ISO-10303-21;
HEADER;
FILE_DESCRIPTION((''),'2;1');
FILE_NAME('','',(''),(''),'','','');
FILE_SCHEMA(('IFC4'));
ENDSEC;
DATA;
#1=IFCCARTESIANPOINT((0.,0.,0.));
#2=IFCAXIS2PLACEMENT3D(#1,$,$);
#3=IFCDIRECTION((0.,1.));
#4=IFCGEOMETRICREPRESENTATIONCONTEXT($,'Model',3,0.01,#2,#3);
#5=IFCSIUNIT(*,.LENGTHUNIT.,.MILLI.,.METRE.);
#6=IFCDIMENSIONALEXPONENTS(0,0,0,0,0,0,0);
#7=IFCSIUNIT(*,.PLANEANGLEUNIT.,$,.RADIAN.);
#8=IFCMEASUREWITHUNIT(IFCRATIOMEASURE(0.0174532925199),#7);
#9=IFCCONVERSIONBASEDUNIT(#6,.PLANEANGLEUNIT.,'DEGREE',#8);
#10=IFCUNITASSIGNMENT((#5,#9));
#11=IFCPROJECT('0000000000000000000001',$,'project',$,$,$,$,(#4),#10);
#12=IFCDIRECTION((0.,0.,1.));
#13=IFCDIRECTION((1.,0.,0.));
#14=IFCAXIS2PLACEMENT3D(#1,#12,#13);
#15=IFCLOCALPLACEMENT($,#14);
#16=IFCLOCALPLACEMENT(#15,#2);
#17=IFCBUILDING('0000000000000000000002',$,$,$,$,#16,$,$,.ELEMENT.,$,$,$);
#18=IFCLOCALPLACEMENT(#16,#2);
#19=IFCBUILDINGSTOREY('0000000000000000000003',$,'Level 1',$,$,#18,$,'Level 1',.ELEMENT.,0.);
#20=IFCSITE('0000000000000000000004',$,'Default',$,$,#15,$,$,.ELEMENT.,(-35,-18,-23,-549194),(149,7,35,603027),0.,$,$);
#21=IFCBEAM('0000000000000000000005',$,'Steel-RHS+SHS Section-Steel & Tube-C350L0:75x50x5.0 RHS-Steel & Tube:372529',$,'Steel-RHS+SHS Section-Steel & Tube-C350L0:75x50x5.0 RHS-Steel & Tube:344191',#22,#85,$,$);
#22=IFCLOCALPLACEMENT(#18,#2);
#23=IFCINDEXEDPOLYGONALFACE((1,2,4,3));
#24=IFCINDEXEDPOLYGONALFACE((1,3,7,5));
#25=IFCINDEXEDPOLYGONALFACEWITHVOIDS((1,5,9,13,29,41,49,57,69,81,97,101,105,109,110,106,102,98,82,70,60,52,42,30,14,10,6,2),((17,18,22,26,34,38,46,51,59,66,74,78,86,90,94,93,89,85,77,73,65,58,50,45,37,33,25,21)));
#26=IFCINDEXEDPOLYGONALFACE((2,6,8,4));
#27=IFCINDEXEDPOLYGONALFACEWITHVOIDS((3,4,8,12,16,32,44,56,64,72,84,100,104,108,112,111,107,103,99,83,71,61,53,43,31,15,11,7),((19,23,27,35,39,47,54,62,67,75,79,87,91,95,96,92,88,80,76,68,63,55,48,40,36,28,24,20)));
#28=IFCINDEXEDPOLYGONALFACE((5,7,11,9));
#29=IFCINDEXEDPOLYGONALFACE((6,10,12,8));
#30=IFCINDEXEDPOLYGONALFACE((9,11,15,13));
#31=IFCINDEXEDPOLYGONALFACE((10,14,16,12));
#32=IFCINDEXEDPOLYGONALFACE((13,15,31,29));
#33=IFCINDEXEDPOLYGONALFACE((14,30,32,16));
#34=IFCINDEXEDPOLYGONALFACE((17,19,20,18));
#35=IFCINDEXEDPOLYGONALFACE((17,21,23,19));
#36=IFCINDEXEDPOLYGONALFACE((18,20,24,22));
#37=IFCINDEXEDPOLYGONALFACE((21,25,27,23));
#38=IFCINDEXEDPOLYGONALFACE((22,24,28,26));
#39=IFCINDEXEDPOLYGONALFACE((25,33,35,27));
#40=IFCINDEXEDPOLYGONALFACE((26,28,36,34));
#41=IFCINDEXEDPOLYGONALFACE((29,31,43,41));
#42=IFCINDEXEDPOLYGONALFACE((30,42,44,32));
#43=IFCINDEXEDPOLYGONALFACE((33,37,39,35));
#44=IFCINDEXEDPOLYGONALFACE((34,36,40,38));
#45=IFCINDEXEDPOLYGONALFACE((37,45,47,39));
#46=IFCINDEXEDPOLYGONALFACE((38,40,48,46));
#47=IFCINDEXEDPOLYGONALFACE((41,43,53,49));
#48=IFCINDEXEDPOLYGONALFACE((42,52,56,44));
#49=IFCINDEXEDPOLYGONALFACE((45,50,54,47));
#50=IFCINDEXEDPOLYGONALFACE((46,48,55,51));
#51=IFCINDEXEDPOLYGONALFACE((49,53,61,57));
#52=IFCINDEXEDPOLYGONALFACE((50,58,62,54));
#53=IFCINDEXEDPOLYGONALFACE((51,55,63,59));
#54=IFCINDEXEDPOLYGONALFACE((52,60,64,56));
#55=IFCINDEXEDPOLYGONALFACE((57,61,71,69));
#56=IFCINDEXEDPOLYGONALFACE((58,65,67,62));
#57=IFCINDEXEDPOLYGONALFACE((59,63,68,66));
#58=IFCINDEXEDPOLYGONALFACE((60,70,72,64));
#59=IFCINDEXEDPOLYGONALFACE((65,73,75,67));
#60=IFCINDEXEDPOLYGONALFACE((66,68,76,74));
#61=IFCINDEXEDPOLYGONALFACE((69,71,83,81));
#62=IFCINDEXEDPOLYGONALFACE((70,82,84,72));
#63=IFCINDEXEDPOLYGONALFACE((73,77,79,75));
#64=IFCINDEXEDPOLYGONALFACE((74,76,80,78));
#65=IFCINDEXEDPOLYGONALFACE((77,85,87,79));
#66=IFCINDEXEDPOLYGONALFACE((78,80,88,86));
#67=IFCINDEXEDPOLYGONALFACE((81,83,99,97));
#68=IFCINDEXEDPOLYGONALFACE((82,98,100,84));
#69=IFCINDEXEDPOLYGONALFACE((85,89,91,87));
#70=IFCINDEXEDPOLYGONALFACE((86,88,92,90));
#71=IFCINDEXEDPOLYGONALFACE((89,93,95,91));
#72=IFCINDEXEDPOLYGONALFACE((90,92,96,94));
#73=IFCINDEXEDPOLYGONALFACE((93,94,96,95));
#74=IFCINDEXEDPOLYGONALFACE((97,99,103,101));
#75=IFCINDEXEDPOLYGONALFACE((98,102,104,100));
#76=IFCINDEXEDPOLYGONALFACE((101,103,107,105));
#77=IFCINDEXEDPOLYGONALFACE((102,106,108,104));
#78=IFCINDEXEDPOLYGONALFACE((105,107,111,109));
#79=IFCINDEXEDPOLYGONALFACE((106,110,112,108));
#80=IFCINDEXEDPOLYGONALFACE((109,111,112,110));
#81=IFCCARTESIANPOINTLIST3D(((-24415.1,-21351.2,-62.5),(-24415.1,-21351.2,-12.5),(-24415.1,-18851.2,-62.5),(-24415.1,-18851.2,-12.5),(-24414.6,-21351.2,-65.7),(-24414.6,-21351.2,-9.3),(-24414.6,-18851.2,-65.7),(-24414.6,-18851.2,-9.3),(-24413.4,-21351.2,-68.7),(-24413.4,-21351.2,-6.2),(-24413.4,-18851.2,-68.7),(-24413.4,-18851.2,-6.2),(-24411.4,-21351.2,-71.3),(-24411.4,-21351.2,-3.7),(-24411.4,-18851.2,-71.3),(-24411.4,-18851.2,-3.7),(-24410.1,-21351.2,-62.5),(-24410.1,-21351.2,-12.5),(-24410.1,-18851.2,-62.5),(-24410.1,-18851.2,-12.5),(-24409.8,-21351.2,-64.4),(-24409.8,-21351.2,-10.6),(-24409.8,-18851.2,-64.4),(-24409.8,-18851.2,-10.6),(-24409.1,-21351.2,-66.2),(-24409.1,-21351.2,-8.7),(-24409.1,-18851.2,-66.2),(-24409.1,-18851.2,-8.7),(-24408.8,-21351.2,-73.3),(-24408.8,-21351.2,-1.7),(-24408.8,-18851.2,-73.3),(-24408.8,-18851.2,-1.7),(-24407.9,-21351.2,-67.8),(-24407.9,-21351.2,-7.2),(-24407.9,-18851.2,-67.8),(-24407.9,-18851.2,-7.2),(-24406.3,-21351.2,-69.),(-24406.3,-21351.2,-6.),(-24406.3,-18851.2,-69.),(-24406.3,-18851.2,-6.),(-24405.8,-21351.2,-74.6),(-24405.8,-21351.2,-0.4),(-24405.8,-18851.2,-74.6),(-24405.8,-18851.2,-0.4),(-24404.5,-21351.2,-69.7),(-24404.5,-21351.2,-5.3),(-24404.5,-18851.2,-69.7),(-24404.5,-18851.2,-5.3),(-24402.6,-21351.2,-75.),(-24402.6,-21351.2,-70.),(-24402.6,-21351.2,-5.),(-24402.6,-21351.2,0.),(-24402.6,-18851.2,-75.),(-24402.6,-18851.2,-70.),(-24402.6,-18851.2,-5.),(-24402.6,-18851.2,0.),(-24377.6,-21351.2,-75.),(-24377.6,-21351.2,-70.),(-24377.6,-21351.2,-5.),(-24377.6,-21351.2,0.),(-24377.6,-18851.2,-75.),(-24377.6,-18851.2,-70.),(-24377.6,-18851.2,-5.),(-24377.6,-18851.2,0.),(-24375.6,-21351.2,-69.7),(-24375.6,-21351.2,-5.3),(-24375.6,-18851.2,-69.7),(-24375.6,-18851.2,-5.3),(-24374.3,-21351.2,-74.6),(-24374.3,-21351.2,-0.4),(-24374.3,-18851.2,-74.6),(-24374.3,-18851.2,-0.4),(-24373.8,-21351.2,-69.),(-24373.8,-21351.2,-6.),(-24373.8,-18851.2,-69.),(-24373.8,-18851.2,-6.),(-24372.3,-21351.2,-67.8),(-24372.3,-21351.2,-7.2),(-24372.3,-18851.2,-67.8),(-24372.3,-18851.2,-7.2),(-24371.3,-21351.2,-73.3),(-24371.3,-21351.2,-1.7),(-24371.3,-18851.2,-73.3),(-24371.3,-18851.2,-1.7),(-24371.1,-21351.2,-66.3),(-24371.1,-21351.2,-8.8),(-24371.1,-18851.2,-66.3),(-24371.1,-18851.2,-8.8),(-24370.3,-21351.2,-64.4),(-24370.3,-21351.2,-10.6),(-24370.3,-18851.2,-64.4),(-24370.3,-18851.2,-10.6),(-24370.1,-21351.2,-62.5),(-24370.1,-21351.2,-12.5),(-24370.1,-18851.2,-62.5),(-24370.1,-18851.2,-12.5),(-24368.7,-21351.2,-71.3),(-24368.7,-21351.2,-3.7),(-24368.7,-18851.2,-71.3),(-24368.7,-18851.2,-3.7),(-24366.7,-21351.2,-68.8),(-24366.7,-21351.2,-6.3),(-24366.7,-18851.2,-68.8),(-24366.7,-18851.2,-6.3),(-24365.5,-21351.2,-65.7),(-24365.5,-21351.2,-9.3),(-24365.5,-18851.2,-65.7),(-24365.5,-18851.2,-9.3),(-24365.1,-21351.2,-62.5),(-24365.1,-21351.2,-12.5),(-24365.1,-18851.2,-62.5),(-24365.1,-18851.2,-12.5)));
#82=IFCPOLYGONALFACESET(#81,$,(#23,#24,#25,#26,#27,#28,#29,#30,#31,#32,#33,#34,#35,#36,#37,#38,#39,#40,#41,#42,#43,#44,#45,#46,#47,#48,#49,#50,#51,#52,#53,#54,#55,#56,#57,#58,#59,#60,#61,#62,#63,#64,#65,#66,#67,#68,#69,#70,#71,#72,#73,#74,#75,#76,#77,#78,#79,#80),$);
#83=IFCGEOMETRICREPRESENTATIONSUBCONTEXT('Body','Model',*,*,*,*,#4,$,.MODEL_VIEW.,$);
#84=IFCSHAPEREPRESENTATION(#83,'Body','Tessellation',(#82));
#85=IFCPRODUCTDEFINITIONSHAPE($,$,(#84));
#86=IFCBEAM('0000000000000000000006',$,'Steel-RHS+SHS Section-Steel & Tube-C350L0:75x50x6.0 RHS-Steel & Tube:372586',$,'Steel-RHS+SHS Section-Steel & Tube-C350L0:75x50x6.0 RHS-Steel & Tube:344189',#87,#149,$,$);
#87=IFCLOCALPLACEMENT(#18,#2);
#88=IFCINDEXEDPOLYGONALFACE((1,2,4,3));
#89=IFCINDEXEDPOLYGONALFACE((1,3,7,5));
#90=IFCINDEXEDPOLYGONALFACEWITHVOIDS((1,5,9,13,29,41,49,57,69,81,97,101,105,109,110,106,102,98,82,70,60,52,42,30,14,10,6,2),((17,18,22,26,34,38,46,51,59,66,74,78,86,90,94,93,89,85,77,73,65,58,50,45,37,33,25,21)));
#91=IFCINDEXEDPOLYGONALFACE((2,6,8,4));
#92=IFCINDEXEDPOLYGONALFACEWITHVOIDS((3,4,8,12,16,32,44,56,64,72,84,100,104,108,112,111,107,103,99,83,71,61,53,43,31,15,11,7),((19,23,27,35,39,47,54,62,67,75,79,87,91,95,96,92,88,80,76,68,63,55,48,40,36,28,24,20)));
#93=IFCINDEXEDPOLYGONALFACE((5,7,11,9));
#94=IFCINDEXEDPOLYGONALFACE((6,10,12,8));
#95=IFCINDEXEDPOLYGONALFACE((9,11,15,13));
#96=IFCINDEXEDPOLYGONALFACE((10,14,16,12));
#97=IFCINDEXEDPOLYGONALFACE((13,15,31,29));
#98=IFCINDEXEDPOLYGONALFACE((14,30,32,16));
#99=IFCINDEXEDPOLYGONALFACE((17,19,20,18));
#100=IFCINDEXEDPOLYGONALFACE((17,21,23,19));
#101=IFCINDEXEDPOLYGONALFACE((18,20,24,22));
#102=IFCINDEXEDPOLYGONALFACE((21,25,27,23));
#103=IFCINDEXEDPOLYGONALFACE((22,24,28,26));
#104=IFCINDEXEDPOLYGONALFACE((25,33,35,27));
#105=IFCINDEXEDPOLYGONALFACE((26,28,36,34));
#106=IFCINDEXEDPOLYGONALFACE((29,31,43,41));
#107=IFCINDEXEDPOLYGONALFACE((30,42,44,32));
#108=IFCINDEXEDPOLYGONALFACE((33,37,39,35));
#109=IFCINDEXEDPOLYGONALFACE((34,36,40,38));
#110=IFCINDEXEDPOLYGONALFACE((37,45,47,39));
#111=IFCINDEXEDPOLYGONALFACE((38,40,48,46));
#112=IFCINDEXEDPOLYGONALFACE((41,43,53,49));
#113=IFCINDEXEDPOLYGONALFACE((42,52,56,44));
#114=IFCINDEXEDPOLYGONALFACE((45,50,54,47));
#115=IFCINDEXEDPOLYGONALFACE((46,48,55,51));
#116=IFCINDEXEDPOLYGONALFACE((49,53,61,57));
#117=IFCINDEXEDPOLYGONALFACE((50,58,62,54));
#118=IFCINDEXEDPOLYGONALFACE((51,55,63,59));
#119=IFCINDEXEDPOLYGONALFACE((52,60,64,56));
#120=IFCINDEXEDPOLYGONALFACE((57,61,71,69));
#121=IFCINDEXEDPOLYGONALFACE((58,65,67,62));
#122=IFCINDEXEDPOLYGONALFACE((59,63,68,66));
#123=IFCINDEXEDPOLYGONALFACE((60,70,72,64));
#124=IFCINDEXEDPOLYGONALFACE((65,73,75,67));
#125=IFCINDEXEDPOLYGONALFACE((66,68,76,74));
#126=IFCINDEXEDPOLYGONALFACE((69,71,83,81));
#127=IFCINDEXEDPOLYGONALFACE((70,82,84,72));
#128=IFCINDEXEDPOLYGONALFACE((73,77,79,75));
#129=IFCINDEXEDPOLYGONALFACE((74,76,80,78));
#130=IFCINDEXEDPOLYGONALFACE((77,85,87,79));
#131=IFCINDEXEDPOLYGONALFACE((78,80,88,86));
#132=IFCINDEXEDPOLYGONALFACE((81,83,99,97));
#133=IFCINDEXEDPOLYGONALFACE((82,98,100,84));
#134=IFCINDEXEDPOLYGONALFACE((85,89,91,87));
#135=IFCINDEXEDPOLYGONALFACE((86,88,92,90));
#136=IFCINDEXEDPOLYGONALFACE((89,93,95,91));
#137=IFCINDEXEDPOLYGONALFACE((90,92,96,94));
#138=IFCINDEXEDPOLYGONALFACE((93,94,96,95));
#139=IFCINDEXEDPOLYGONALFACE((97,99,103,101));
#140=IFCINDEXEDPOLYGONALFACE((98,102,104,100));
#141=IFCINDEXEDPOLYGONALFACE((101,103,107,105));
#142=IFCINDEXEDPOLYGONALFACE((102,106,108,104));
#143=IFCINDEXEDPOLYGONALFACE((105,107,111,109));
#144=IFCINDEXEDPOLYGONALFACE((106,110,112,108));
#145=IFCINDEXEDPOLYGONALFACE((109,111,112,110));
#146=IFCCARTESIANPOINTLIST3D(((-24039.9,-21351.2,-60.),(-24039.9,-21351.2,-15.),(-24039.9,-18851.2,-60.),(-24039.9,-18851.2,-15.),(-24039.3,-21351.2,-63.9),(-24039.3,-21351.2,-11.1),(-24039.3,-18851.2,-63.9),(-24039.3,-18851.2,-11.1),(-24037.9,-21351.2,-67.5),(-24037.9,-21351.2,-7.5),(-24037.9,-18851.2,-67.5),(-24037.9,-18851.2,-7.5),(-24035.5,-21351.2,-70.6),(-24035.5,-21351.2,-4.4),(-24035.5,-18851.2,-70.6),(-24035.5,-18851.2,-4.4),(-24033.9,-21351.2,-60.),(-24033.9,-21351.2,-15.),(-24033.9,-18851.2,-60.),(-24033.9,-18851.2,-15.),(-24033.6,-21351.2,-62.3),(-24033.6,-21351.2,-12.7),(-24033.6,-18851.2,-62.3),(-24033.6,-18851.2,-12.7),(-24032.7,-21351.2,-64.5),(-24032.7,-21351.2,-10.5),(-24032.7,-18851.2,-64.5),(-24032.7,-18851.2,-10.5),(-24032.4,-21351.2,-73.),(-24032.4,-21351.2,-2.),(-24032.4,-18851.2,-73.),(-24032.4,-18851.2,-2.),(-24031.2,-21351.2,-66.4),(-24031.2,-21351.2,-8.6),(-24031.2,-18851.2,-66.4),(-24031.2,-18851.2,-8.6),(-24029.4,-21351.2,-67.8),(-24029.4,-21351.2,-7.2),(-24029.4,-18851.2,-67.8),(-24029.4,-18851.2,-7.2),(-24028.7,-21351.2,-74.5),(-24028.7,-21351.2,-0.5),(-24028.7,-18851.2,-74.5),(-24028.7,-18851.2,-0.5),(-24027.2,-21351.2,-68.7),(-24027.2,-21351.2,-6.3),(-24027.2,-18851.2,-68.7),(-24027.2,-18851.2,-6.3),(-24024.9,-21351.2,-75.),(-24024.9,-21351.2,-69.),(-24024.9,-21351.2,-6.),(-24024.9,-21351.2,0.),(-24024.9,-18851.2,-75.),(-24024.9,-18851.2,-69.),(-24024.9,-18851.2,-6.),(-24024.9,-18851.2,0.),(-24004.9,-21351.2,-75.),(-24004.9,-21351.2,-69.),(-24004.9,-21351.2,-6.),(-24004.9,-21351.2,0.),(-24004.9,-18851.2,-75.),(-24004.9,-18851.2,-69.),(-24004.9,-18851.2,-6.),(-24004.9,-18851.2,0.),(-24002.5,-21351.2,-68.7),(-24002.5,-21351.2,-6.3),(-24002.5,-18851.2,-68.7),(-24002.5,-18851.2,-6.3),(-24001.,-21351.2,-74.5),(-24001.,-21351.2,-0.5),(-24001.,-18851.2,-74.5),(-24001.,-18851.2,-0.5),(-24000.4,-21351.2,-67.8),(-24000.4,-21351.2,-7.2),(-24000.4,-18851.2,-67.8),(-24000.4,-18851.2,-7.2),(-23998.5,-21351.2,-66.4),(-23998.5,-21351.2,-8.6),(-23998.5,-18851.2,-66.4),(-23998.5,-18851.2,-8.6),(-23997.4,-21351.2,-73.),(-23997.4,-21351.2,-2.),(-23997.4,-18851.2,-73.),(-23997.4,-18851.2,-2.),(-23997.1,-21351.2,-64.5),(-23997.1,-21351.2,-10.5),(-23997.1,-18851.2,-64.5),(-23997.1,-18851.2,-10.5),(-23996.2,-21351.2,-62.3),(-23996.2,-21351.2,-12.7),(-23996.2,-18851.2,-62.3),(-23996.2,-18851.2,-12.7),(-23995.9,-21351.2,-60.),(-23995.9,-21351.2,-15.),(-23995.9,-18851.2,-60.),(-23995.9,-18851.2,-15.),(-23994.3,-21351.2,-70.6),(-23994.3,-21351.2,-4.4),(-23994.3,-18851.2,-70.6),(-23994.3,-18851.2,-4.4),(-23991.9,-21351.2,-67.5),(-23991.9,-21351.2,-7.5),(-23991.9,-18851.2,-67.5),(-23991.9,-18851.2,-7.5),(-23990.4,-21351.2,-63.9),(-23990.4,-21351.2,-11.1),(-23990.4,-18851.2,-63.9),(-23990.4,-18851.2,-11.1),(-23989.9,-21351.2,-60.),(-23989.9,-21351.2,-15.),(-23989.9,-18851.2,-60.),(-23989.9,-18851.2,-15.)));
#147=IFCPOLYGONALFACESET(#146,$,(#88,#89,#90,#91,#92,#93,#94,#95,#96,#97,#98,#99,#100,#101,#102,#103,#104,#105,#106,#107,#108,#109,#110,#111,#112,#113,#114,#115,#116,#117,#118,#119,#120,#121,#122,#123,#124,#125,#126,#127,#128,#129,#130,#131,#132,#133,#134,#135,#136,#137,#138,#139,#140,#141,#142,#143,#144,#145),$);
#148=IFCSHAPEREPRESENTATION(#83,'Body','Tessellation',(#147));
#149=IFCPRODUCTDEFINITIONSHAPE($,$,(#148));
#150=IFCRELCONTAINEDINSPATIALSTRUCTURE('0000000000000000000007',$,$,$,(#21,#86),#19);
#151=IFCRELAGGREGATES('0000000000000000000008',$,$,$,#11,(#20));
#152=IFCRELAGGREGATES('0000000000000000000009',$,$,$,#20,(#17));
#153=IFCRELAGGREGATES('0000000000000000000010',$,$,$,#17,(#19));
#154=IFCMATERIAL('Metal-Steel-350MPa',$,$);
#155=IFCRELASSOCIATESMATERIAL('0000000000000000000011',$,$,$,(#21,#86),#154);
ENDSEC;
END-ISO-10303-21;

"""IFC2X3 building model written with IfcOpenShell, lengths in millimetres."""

from ifc_helpers import new_model, entity, si_unit, converted_unit, direction, frame, frame_2d, origin, origin_with_axes, place, context, subcontext, project, spatial, polyline, circle_curve, parameter, trimmed, segment, composite_curve, outline, extrude, material, element, save


model = new_model("IFC2X3")

# Units and contexts
model_context = context("Model", 3, precision=0.01, world=origin(), true_north=direction((0.0, 1.0)))
body_context = subcontext(model_context, "Body", "Model", "MODEL_VIEW")
ifc_project = project(units=[si_unit("LENGTHUNIT", "METRE", prefix="MILLI"), converted_unit("PLANEANGLEUNIT", "DEGREE", entity("IfcRatioMeasure", 0.0174532925199), si_unit("PLANEANGLEUNIT", "RADIAN"), dimensions=[0, 0, 0, 0, 0, 0, 0])], contexts=[model_context])

# Site, building, storey
site_placement = place(None, origin_with_axes())
site = spatial("IfcSite", under=ifc_project, at=site_placement, Name="Default", CompositionType="ELEMENT", RefLatitude=(-35, -18, -23, -549194), RefLongitude=(149, 7, 35, 603027), RefElevation=0.0)
building_placement = place(site_placement, origin())
building = spatial("IfcBuilding", under=site, at=building_placement, CompositionType="ELEMENT")
storey_placement = place(building_placement, origin())
storey = spatial("IfcBuildingStorey", under=building, at=storey_placement, Name="Level 1", LongName="Level 1", CompositionType="ELEMENT", Elevation=0.0)

# Beams
ifc_material = material(Name="Metal-Steel-350MPa")
beam_1_placement = place(storey_placement, frame((-24390.1, -18851.2, 0.0), z_axis=(0.0, 0.0, 1.0), x_axis=(0.0, -1.0, 0.0)))
element("IfcBeam", 1, at=beam_1_placement, inside=storey, material=ifc_material, Name="Steel-RHS+SHS Section-Steel & Tube-C350L0:75x50x5.0 RHS-Steel & Tube:372529", ObjectType="Steel-RHS+SHS Section-Steel & Tube-C350L0:75x50x5.0 RHS-Steel & Tube:344191", context=body_context, shape_type="SweptSolid", body=[
    extrude(outline(composite_curve([segment(trimmed(circle_curve(frame_2d((-12.5, -25.0), x_axis=(1.0, 0.0)), 12.5), [parameter(180.0)], [parameter(270.0)], True, "PARAMETER"), True, "CONTINUOUS"), segment(polyline([(-12.5, -37.5), (12.5, -37.5)]), True, "CONTINUOUS"), segment(trimmed(circle_curve(frame_2d((12.5, -25.0), x_axis=(1.0, 0.0)), 12.5), [parameter(270.0)], [parameter(0.0)], True, "PARAMETER"), True, "CONTINUOUS"), segment(polyline([(25.0, -25.0), (25.0, 25.0)]), True, "CONTINUOUS"), segment(trimmed(circle_curve(frame_2d((12.5, 25.0), x_axis=(1.0, 0.0)), 12.5), [parameter(0.0)], [parameter(90.0)], True, "PARAMETER"), True, "CONTINUOUS"), segment(polyline([(12.5, 37.5), (-12.5, 37.5)]), True, "CONTINUOUS"), segment(trimmed(circle_curve(frame_2d((-12.5, 25.0), x_axis=(1.0, 0.0)), 12.5), [parameter(90.0)], [parameter(180.0)], True, "PARAMETER"), True, "CONTINUOUS"), segment(polyline([(-25.0, 25.0), (-25.0, -25.0)]), True, "CONTINUOUS")], self_intersect=False), holes=[composite_curve([segment(polyline([(12.5, -32.5), (-12.5, -32.5)]), True, "CONTINUOUS"), segment(trimmed(circle_curve(frame_2d((-12.5, -25.0), x_axis=(1.0, 0.0)), 7.5), [parameter(180.0)], [parameter(270.0)], True, "PARAMETER"), False, "CONTINUOUS"), segment(polyline([(-20.0, -25.0), (-20.0, 25.0)]), True, "CONTINUOUS"), segment(trimmed(circle_curve(frame_2d((-12.5, 25.0), x_axis=(1.0, 0.0)), 7.5), [parameter(90.0)], [parameter(180.0)], True, "PARAMETER"), False, "CONTINUOUS"), segment(polyline([(-12.5, 32.5), (12.5, 32.5)]), True, "CONTINUOUS"), segment(trimmed(circle_curve(frame_2d((12.5, 25.0), x_axis=(1.0, 0.0)), 7.5), [parameter(360.0)], [parameter(90.0)], True, "PARAMETER"), False, "CONTINUOUS"), segment(polyline([(20.0, 25.0), (20.0, -25.0)]), True, "CONTINUOUS"), segment(trimmed(circle_curve(frame_2d((12.5, -25.0), x_axis=(1.0, 0.0)), 7.5), [parameter(270.0)], [parameter(360.0)], True, "PARAMETER"), False, "CONTINUOUS")], self_intersect=False)]), frame((0.0, 0.0, -37.5), z_axis=(1.0, 0.0, 0.0), x_axis=(0.0, -1.0, 0.0)), (0.0, 0.0, 1.0), 2500.0),
])
beam_2_placement = place(storey_placement, frame((-24014.9, -18851.2, 0.0), z_axis=(0.0, 0.0, 1.0), x_axis=(0.0, -1.0, 0.0)))
element("IfcBeam", 2, at=beam_2_placement, inside=storey, material=ifc_material, Name="Steel-RHS+SHS Section-Steel & Tube-C350L0:75x50x6.0 RHS-Steel & Tube:372586", ObjectType="Steel-RHS+SHS Section-Steel & Tube-C350L0:75x50x6.0 RHS-Steel & Tube:344189", context=body_context, shape_type="SweptSolid", body=[
    extrude(outline(composite_curve([segment(trimmed(circle_curve(frame_2d((-10.0, -22.5), x_axis=(1.0, 0.0)), 15.0), [parameter(180.0)], [parameter(270.0)], True, "PARAMETER"), True, "CONTINUOUS"), segment(polyline([(-10.0, -37.5), (10.0, -37.5)]), True, "CONTINUOUS"), segment(trimmed(circle_curve(frame_2d((10.0, -22.5), x_axis=(1.0, 0.0)), 15.0), [parameter(270.0)], [parameter(0.0)], True, "PARAMETER"), True, "CONTINUOUS"), segment(polyline([(25.0, -22.5), (25.0, 22.5)]), True, "CONTINUOUS"), segment(trimmed(circle_curve(frame_2d((10.0, 22.5), x_axis=(1.0, 0.0)), 15.0), [parameter(0.0)], [parameter(90.0)], True, "PARAMETER"), True, "CONTINUOUS"), segment(polyline([(10.0, 37.5), (-10.0, 37.5)]), True, "CONTINUOUS"), segment(trimmed(circle_curve(frame_2d((-10.0, 22.5), x_axis=(1.0, 0.0)), 15.0), [parameter(90.0)], [parameter(180.0)], True, "PARAMETER"), True, "CONTINUOUS"), segment(polyline([(-25.0, 22.5), (-25.0, -22.5)]), True, "CONTINUOUS")], self_intersect=False), holes=[composite_curve([segment(polyline([(10.0, -31.5), (-10.0, -31.5)]), True, "CONTINUOUS"), segment(trimmed(circle_curve(frame_2d((-10.0, -22.5), x_axis=(1.0, 0.0)), 9.0), [parameter(180.0)], [parameter(270.0)], True, "PARAMETER"), False, "CONTINUOUS"), segment(polyline([(-19.0, -22.5), (-19.0, 22.5)]), True, "CONTINUOUS"), segment(trimmed(circle_curve(frame_2d((-10.0, 22.5), x_axis=(1.0, 0.0)), 9.0), [parameter(90.0)], [parameter(180.0)], True, "PARAMETER"), False, "CONTINUOUS"), segment(polyline([(-10.0, 31.5), (10.0, 31.5)]), True, "CONTINUOUS"), segment(trimmed(circle_curve(frame_2d((10.0, 22.5), x_axis=(1.0, 0.0)), 9.0), [parameter(360.0)], [parameter(90.0)], True, "PARAMETER"), False, "CONTINUOUS"), segment(polyline([(19.0, 22.5), (19.0, -22.5)]), True, "CONTINUOUS"), segment(trimmed(circle_curve(frame_2d((10.0, -22.5), x_axis=(1.0, 0.0)), 9.0), [parameter(270.0)], [parameter(0.0)], True, "PARAMETER"), False, "CONTINUOUS")], self_intersect=False)]), frame((0.0, 0.0, -37.5), z_axis=(1.0, 0.0, 0.0), x_axis=(0.0, -1.0, 0.0)), (0.0, 0.0, 1.0), 2500.0),
])

save(model, "model.ifc")
